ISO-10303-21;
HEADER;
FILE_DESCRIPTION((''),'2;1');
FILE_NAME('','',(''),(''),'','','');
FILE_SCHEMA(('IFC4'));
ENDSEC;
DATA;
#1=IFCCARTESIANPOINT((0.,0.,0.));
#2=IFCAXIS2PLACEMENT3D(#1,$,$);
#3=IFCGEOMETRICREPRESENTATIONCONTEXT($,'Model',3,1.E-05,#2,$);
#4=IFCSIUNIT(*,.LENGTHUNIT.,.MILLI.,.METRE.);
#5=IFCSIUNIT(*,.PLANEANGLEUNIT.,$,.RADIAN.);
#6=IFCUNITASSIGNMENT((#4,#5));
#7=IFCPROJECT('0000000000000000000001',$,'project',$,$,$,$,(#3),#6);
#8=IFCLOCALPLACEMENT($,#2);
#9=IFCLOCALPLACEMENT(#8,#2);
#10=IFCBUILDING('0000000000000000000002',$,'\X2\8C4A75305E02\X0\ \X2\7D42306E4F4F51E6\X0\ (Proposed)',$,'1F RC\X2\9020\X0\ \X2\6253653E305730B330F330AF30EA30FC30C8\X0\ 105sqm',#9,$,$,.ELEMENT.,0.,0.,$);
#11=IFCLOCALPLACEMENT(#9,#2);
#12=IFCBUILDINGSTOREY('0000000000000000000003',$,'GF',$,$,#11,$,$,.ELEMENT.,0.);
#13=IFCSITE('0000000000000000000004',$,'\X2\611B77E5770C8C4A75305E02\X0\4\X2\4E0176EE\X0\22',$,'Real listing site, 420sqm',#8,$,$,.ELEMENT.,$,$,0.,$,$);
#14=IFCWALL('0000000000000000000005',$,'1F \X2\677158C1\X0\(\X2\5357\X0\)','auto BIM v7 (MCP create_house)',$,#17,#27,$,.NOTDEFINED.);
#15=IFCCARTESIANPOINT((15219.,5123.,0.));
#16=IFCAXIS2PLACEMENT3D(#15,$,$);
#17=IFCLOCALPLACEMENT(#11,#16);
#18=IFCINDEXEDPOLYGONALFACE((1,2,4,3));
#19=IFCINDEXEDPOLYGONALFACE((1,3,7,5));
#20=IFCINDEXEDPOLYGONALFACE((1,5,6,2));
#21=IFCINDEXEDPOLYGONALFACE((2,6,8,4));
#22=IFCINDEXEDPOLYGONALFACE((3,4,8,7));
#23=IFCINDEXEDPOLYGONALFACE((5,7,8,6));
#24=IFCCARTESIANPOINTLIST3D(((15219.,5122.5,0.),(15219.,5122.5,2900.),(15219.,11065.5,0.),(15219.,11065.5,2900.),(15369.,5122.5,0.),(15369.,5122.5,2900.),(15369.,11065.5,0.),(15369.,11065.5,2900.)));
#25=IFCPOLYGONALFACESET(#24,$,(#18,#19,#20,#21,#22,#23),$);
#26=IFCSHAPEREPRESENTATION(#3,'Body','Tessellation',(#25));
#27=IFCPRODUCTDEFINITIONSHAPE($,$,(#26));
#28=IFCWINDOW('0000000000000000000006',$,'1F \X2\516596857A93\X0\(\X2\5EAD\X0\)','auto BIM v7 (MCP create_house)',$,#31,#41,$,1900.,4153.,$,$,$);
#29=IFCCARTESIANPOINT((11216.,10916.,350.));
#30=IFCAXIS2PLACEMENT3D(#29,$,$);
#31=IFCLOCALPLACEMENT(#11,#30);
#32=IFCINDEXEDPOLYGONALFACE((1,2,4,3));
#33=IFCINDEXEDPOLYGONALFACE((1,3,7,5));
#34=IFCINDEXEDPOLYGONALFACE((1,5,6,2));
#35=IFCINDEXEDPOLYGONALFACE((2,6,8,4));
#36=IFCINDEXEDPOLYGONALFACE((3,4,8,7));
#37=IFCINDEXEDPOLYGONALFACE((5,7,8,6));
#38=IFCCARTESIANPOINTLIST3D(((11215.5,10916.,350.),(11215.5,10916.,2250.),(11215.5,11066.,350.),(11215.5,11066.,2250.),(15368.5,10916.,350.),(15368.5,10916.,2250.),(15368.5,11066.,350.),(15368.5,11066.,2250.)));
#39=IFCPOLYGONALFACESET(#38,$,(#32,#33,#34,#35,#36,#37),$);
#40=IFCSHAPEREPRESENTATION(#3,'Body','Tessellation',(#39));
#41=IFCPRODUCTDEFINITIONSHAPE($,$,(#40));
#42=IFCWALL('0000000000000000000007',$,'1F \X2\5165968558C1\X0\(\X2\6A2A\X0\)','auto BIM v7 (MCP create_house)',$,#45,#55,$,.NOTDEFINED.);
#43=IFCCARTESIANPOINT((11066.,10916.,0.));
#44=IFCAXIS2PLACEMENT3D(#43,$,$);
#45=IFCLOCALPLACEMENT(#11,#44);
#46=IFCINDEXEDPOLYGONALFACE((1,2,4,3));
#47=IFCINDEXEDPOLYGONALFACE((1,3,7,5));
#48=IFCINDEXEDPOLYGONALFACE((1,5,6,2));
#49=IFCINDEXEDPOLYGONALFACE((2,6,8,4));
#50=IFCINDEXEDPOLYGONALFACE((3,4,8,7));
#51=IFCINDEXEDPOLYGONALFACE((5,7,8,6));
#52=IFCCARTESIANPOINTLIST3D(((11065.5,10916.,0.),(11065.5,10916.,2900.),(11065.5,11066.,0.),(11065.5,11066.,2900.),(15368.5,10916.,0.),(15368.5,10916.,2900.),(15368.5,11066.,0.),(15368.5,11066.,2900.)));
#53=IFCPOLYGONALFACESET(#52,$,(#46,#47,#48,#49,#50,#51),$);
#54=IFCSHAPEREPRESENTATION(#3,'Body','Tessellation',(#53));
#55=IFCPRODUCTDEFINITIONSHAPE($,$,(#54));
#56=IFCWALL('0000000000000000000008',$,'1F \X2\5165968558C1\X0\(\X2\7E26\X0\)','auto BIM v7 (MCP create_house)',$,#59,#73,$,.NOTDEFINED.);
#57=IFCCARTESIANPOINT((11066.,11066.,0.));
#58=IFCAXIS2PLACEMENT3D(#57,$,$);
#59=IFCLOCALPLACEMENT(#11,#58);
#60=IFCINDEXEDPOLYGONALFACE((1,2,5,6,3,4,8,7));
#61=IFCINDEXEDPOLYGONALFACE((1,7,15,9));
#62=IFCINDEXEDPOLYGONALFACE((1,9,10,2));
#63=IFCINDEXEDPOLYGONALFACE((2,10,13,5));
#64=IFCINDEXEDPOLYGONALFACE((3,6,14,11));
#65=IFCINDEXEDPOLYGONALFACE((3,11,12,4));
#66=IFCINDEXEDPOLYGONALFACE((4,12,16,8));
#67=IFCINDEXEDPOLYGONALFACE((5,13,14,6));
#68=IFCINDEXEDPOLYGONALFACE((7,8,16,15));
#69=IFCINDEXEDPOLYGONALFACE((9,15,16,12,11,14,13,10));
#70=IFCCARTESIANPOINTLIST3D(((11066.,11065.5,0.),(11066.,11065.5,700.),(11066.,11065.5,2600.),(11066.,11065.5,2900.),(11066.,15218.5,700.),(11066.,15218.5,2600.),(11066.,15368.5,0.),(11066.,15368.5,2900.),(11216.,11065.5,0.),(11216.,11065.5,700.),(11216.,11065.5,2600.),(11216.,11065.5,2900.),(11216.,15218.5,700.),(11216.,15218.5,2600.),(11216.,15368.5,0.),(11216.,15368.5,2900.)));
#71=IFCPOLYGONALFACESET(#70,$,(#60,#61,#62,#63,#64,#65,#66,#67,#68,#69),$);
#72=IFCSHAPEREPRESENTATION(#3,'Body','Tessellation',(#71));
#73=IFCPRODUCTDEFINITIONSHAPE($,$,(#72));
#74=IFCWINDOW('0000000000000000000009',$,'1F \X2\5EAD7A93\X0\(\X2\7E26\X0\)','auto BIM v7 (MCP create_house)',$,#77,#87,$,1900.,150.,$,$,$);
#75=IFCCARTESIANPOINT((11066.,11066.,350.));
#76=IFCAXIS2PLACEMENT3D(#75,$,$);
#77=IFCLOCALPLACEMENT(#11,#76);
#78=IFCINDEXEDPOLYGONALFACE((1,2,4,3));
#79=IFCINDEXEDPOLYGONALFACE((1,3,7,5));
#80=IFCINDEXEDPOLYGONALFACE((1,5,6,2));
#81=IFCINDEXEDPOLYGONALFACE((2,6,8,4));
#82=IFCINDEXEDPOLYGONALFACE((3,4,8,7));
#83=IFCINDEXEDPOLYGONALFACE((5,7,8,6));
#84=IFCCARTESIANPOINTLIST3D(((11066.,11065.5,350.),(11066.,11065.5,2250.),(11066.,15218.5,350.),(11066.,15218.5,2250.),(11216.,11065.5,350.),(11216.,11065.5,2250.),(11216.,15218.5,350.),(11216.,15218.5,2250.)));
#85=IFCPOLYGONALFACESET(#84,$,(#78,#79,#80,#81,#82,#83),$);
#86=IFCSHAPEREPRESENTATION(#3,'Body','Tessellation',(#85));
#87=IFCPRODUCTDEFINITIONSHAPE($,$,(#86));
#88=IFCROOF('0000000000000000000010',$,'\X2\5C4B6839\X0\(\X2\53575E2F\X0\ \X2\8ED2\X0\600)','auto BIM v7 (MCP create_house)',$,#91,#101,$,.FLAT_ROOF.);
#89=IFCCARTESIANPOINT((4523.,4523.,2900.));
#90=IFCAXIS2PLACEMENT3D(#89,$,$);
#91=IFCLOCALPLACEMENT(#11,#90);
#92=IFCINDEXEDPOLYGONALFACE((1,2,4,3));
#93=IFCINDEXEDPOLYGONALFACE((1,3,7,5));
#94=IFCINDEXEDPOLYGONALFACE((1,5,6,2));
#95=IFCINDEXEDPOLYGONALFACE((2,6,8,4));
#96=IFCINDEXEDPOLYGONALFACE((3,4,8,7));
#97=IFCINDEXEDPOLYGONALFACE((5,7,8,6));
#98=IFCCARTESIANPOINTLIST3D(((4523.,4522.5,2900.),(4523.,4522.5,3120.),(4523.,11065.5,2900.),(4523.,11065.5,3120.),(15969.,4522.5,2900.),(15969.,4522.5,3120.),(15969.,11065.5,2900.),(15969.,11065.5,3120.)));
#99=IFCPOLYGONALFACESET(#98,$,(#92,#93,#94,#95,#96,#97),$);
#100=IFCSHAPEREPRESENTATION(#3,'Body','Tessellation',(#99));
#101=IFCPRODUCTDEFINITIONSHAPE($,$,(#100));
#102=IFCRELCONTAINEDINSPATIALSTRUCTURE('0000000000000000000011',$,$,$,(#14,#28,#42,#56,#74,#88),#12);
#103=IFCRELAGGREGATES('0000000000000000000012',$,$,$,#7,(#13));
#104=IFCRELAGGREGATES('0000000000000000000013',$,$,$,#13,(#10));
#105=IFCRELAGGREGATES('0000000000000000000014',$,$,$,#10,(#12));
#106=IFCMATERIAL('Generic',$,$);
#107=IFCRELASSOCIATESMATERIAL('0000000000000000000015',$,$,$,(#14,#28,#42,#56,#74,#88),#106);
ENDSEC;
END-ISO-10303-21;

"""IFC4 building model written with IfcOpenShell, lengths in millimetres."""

from ifc_helpers import new_model, si_unit, frame, frame_2d, origin, place, context, project, spatial, rectangle, extrude, material, element, fill, save


model = new_model("IFC4")

# Units and contexts
model_context = context("Model", 3, precision=1e-05, world=origin())
ifc_project = project(units=[si_unit("LENGTHUNIT", "METRE", prefix="MILLI"), si_unit("PLANEANGLEUNIT", "RADIAN")], contexts=[model_context])

# Site, building, storey
site_placement = place(None, origin())
site = spatial("IfcSite", under=ifc_project, at=site_placement, Name="愛知県豊田市4丁目22", ObjectType="Real listing site, 420sqm", CompositionType="ELEMENT", RefElevation=0.0)
building_placement = place(site_placement, origin())
building = spatial("IfcBuilding", under=site, at=building_placement, Name="豊田市 終の住処 (Proposed)", ObjectType="1F RC造 打放しコンクリート 105sqm", CompositionType="ELEMENT", ElevationOfRefHeight=0.0, ElevationOfTerrain=0.0)
storey_placement = place(building_placement, origin())
storey = spatial("IfcBuildingStorey", under=building, at=storey_placement, Name="GF", CompositionType="ELEMENT", Elevation=0.0)

# Shared definitions
ifc_material = material(Name="Generic")

# Wall, opening, window
wall_1_placement = place(storey_placement, frame((15219.0, 5123.0, 0.0)))
wall_1 = element("IfcWall", 1, at=wall_1_placement, inside=storey, material=ifc_material, Name="1F 東壁(南)", Description="auto BIM v7 (MCP create_house)", PredefinedType="NOTDEFINED", context=model_context, shape_type="SweptSolid", body=[
    extrude(rectangle(XDim=150.0, YDim=5943.0, at=frame_2d((75.0, 2971.0))), frame((15219.0, 5123.0, 0.0)), (0.0, 0.0, 1.0), 2900.0),
])
opening_1_placement = place(storey_placement, frame((11216.0, 10916.0, 350.0)))
opening_1 = element("IfcOpeningElement", 2, at=opening_1_placement, cuts=wall_1, PredefinedType="NOTDEFINED", context=model_context, shape_type="SweptSolid", body=[
    extrude(rectangle(XDim=4153.0, YDim=150.0, at=frame_2d((2076.0, 75.0))), frame((11216.0, 10916.0, 350.0)), (0.0, 0.0, 1.0), 1900.0),
])
window_1_placement = place(storey_placement, frame((11216.0, 10916.0, 350.0)))
window_1 = element("IfcWindow", 3, at=window_1_placement, inside=storey, material=ifc_material, Name="1F 入隅窓(庭)", Description="auto BIM v7 (MCP create_house)", OverallHeight=1900.0, OverallWidth=4153.0, context=model_context, shape_type="SweptSolid", body=[
    extrude(rectangle(XDim=4153.0, YDim=150.0, at=frame_2d((2076.0, 75.0))), frame((11216.0, 10916.0, 350.0)), (0.0, 0.0, 1.0), 1900.0),
])
fill(opening_1, window_1)

# Wall
wall_2_placement = place(storey_placement, frame((11066.0, 10916.0, 0.0)))
element("IfcWall", 4, at=wall_2_placement, inside=storey, material=ifc_material, Name="1F 入隅壁(横)", Description="auto BIM v7 (MCP create_house)", PredefinedType="NOTDEFINED", context=model_context, shape_type="SweptSolid", body=[
    extrude(rectangle(XDim=4303.0, YDim=150.0, at=frame_2d((2151.0, 75.0))), frame((11066.0, 10916.0, 0.0)), (0.0, 0.0, 1.0), 2900.0),
])

# Wall, opening, window
wall_3_placement = place(storey_placement, frame((11066.0, 11066.0, 0.0)))
wall_3 = element("IfcWall", 5, at=wall_3_placement, inside=storey, material=ifc_material, Name="1F 入隅壁(縦)", Description="auto BIM v7 (MCP create_house)", PredefinedType="NOTDEFINED", context=model_context, shape_type="SweptSolid", body=[
    extrude(rectangle(XDim=150.0, YDim=4303.0, at=frame_2d((75.0, 2151.0))), frame((11066.0, 11066.0, 0.0)), (0.0, 0.0, 1.0), 2900.0),
])
opening_2_placement = place(storey_placement, frame((11066.0, 11066.0, 350.0)))
opening_2 = element("IfcOpeningElement", 6, at=opening_2_placement, cuts=wall_3, PredefinedType="NOTDEFINED", context=model_context, shape_type="SweptSolid", body=[
    extrude(rectangle(XDim=150.0, YDim=4153.0, at=frame_2d((75.0, 2076.0))), frame((11066.0, 11066.0, 350.0)), (0.0, 0.0, 1.0), 1900.0),
])
window_2_placement = place(storey_placement, frame((11066.0, 11066.0, 350.0)))
window_2 = element("IfcWindow", 7, at=window_2_placement, inside=storey, material=ifc_material, Name="1F 庭窓(縦)", Description="auto BIM v7 (MCP create_house)", OverallHeight=1900.0, OverallWidth=150.0, context=model_context, shape_type="SweptSolid", body=[
    extrude(rectangle(XDim=150.0, YDim=4153.0, at=frame_2d((75.0, 2076.0))), frame((11066.0, 11066.0, 350.0)), (0.0, 0.0, 1.0), 1900.0),
])
fill(opening_2, window_2)

# Roof
roof_1_placement = place(storey_placement, frame((4523.0, 4523.0, 2900.0)))
element("IfcRoof", 8, at=roof_1_placement, inside=storey, material=ifc_material, Name="屋根(南帯 軒600)", Description="auto BIM v7 (MCP create_house)", PredefinedType="FLAT_ROOF", context=model_context, shape_type="SweptSolid", body=[
    extrude(rectangle(XDim=11446.0, YDim=6543.0, at=frame_2d((5723.0, 3271.0))), frame((4523.0, 4523.0, 2900.0)), (0.0, 0.0, 1.0), 220.0),
])

save(model, "model.ifc")
